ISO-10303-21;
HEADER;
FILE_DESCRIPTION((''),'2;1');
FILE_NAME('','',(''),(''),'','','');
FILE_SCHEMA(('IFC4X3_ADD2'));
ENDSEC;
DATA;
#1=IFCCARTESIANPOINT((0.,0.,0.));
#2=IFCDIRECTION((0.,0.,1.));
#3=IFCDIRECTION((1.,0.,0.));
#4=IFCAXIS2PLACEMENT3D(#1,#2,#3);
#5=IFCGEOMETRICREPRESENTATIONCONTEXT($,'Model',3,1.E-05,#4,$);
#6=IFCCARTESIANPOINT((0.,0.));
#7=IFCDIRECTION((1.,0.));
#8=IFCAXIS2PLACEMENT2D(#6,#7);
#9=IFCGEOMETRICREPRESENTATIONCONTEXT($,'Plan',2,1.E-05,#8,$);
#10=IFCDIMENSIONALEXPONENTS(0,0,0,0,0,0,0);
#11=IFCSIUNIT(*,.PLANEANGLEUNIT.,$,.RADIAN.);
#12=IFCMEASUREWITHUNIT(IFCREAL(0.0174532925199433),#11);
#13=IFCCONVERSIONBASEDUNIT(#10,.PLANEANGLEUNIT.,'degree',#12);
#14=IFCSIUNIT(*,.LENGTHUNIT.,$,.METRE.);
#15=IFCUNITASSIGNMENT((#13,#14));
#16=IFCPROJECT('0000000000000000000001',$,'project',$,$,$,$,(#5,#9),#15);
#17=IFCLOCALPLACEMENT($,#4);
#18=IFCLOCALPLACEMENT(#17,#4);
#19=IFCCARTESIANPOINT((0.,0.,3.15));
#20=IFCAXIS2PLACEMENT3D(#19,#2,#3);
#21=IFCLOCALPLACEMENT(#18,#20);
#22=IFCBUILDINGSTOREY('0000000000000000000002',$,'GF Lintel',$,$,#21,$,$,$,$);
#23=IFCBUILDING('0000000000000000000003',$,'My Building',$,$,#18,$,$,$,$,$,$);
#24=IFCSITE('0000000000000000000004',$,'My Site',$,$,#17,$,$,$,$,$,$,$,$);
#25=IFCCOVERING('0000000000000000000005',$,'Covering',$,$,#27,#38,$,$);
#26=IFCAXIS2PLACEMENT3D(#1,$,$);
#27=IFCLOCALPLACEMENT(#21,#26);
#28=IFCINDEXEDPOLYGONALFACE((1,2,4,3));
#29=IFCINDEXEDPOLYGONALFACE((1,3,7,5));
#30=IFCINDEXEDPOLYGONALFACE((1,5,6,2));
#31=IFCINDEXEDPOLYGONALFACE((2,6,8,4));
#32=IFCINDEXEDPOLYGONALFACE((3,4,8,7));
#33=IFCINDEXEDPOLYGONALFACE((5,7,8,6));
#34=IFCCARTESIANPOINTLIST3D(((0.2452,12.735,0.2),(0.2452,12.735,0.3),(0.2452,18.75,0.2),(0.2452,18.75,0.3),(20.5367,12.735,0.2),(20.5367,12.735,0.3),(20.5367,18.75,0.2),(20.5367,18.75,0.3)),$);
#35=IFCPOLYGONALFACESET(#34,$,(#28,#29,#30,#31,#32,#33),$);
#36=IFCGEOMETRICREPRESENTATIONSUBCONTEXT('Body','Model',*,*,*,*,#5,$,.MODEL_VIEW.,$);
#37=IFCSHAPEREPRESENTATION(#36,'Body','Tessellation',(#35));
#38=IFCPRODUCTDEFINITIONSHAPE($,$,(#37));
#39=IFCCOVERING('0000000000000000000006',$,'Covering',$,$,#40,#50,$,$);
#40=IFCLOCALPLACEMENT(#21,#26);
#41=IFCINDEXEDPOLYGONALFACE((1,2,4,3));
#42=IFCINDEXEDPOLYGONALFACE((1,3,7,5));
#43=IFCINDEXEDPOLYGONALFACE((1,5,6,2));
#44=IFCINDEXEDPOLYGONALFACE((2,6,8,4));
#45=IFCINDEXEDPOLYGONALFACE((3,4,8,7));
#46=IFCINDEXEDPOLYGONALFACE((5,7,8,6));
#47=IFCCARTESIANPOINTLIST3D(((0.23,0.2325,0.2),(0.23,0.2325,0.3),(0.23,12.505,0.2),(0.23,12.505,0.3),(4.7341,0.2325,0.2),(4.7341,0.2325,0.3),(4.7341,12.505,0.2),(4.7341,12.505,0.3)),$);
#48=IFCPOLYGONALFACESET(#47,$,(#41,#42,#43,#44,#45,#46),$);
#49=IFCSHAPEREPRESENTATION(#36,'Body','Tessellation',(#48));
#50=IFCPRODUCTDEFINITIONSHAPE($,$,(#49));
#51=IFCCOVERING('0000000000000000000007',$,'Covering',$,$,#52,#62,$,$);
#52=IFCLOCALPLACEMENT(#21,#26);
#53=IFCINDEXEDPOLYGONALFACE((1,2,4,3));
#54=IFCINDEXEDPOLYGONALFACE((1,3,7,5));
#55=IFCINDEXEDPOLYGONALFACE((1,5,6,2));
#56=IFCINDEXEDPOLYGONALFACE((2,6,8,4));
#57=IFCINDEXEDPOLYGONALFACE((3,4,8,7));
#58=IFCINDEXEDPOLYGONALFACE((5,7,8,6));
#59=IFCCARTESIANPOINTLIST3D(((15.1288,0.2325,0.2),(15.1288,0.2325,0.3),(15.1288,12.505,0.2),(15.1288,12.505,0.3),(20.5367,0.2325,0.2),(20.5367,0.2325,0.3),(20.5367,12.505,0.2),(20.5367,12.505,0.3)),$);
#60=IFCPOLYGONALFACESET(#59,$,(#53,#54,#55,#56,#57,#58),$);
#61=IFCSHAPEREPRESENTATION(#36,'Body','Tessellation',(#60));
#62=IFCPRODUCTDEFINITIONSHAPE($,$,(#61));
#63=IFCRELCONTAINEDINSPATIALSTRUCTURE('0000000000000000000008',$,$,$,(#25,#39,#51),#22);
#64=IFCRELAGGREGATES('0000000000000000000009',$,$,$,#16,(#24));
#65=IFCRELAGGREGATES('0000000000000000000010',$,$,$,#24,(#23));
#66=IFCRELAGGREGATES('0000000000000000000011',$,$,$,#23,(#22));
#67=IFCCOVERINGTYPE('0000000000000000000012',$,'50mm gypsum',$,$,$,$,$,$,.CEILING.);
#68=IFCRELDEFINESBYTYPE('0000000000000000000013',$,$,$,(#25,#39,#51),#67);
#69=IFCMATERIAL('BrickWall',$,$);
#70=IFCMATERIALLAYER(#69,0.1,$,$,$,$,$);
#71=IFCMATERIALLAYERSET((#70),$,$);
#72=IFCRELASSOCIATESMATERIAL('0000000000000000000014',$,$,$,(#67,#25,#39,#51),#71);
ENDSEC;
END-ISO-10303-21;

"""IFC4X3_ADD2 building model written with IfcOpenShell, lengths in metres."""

from ifc_helpers import new_model, entity, si_unit, converted_unit, frame, origin_with_axes, origin_2d_with_axis, place, context, subcontext, project, spatial, line, indexed_curve, outline, extrude, material, layer, layer_set, layer_usage, type_object, element, save


model = new_model("IFC4X3_ADD2")

# Units and contexts
model_context = context("Model", 3, precision=1e-05, world=origin_with_axes())
plan_context = context("Plan", 2, precision=1e-05, world=origin_2d_with_axis())
body_context = subcontext(model_context, "Body", "Model", "MODEL_VIEW")
ifc_project = project(units=[converted_unit("PLANEANGLEUNIT", "degree", entity("IfcReal", 0.0174532925199433), si_unit("PLANEANGLEUNIT", "RADIAN"), dimensions=[0, 0, 0, 0, 0, 0, 0]), si_unit("LENGTHUNIT", "METRE")], contexts=[model_context, plan_context])

# Site, building, storey
site_placement = place(None, origin_with_axes())
site = spatial("IfcSite", under=ifc_project, at=site_placement, Name="My Site")
building_placement = place(site_placement, origin_with_axes())
building = spatial("IfcBuilding", under=site, at=building_placement, Name="My Building")
storey_placement = place(building_placement, frame((0.0, 0.0, 3.15), z_axis=(0.0, 0.0, 1.0), x_axis=(1.0, 0.0, 0.0)))
storey = spatial("IfcBuildingStorey", under=building, at=storey_placement, Name="GF Lintel")

# Coverings
ifc_material = material(Name="BrickWall")
ifc_layer = layer(ifc_material, 0.1)
ifc_layer_set = layer_set([ifc_layer])
ifc_layer_usage_1 = layer_usage(ifc_layer_set, "AXIS3", "POSITIVE", 0.0)
covering_type = type_object("IfcCoveringType", Name="50mm gypsum", PredefinedType="CEILING", material=ifc_layer_set)
covering_1_placement = place(storey_placement, frame((0.2452, 12.735, 0.2), z_axis=(0.0, 0.0, 1.0), x_axis=(1.0, 0.0, 0.0)))
element("IfcCovering", 1, at=covering_1_placement, inside=storey, type_object=covering_type, material=ifc_layer_usage_1, Name="Covering", context=body_context, shape_type="SweptSolid", body=[
    extrude(outline(indexed_curve([(0.0, 0.0), (20.2915, 0.0), (20.2915, 6.015), (0.0, 6.015)], segments=[line(3, 2), line(2, 1), line(1, 4), line(4, 3)], self_intersect=False)), None, (0.0, 0.0, 1.0), 0.1),
])
ifc_layer_usage_2 = layer_usage(ifc_layer_set, "AXIS3", "POSITIVE", 0.0)
covering_2_placement = place(storey_placement, frame((0.23, 12.505, 0.2), z_axis=(0.0, 0.0, 1.0), x_axis=(0.0, -1.0, 0.0)))
element("IfcCovering", 2, at=covering_2_placement, inside=storey, type_object=covering_type, material=ifc_layer_usage_2, Name="Covering", context=body_context, shape_type="SweptSolid", body=[
    extrude(outline(indexed_curve([(12.2725, 4.5041), (12.2725, 0.0), (0.0, 0.0), (0.0, 4.5041)], segments=[line(4, 1), line(1, 2), line(2, 3), line(3, 4)], self_intersect=False)), None, (0.0, 0.0, 1.0), 0.1),
])
ifc_layer_usage_3 = layer_usage(ifc_layer_set, "AXIS3", "POSITIVE", 0.0)
covering_3_placement = place(storey_placement, frame((15.1288, 12.505, 0.2), z_axis=(0.0, 0.0, 1.0), x_axis=(0.0, -1.0, 0.0)))
element("IfcCovering", 3, at=covering_3_placement, inside=storey, type_object=covering_type, material=ifc_layer_usage_3, Name="Covering", context=body_context, shape_type="SweptSolid", body=[
    extrude(outline(indexed_curve([(0.0, 5.4079), (12.2725, 5.4079), (12.2725, 0.0), (0.0, 0.0)], segments=[line(3, 2), line(2, 1), line(1, 4), line(4, 3)], self_intersect=False)), None, (0.0, 0.0, 1.0), 0.1),
])

save(model, "model.ifc")
